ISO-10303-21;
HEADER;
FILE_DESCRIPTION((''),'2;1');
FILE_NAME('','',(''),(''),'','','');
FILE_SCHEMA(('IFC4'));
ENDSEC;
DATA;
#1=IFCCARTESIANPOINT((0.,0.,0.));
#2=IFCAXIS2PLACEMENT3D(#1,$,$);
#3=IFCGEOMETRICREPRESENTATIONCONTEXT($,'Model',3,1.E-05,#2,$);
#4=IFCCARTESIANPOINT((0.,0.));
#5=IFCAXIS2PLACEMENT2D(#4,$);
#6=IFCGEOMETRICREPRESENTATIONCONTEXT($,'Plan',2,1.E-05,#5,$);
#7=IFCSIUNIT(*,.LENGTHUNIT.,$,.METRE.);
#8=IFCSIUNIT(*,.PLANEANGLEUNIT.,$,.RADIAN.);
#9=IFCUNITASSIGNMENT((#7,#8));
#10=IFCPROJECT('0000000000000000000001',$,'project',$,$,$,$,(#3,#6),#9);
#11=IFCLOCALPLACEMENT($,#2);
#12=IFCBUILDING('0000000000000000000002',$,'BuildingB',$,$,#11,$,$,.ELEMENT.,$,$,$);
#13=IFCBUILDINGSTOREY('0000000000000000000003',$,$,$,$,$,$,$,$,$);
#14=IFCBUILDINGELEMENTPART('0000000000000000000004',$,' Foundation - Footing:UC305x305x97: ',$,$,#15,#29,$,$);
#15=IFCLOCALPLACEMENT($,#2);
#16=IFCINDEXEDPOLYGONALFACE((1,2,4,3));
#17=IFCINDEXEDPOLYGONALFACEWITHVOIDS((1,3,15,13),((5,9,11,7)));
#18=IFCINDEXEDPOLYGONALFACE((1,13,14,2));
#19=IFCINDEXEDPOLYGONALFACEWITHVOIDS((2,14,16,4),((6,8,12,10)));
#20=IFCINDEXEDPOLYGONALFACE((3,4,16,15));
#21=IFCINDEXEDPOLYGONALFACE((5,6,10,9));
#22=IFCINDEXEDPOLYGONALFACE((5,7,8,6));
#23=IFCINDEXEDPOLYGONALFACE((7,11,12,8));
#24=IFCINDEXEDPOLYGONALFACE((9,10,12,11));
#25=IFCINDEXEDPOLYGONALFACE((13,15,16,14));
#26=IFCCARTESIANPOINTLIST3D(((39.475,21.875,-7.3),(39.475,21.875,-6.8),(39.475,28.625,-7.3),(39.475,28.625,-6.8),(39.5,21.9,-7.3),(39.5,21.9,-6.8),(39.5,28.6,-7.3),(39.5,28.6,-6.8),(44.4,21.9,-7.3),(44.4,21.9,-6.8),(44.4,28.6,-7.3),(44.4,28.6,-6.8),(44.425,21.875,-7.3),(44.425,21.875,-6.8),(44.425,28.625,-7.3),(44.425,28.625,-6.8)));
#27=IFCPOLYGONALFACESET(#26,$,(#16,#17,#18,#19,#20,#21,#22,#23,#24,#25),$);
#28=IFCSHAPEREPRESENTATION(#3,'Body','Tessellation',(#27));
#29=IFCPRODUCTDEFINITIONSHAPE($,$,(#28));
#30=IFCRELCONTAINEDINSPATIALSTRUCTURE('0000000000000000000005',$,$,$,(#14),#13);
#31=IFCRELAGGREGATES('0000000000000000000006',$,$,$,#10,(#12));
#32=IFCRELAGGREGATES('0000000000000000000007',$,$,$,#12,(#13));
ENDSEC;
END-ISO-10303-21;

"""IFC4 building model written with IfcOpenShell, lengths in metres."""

from ifc_helpers import new_model, si_unit, origin, origin_2d, place, context, project, spatial, polyline, outline, extrude, element, save


model = new_model("IFC4")

# Units and contexts
model_context = context("Model", 3, precision=1e-05, world=origin())
plan_context = context("Plan", 2, precision=1e-05, world=origin_2d())
ifc_project = project(units=[si_unit("LENGTHUNIT", "METRE"), si_unit("PLANEANGLEUNIT", "RADIAN")], contexts=[model_context, plan_context])

# Building, storey
building_placement = place(None, origin())
building = spatial("IfcBuilding", under=ifc_project, at=building_placement, Name="BuildingB", CompositionType="ELEMENT")
storey = spatial("IfcBuildingStorey", under=building)

# Building element part, opening
building_element_part_1 = element("IfcBuildingElementPart", 1, inside=storey, Name=" Foundation - Footing:UC305x305x97: ", context=model_context, shape_type="SweptSolid", body=[
    extrude(outline(polyline([(44.425, 21.875, -7.3), (44.425, 28.625, -7.3), (39.475, 28.625, -7.3), (39.475, 21.875, -7.3), (44.425, 21.875, -7.3)])), None, (0.0, 0.0, 1.0), 0.5),
])
element("IfcOpeningElement", 2, inside=storey, cuts=building_element_part_1, context=model_context, shape_type="SweptSolid", body=[
    extrude(outline(polyline([(44.4, 21.9, -7.3), (44.4, 28.6, -7.3), (39.5, 28.6, -7.3), (39.5, 21.9, -7.3), (44.4, 21.9, -7.3)])), None, (0.0, 0.0, 1.0), 0.5),
])

save(model, "model.ifc")
